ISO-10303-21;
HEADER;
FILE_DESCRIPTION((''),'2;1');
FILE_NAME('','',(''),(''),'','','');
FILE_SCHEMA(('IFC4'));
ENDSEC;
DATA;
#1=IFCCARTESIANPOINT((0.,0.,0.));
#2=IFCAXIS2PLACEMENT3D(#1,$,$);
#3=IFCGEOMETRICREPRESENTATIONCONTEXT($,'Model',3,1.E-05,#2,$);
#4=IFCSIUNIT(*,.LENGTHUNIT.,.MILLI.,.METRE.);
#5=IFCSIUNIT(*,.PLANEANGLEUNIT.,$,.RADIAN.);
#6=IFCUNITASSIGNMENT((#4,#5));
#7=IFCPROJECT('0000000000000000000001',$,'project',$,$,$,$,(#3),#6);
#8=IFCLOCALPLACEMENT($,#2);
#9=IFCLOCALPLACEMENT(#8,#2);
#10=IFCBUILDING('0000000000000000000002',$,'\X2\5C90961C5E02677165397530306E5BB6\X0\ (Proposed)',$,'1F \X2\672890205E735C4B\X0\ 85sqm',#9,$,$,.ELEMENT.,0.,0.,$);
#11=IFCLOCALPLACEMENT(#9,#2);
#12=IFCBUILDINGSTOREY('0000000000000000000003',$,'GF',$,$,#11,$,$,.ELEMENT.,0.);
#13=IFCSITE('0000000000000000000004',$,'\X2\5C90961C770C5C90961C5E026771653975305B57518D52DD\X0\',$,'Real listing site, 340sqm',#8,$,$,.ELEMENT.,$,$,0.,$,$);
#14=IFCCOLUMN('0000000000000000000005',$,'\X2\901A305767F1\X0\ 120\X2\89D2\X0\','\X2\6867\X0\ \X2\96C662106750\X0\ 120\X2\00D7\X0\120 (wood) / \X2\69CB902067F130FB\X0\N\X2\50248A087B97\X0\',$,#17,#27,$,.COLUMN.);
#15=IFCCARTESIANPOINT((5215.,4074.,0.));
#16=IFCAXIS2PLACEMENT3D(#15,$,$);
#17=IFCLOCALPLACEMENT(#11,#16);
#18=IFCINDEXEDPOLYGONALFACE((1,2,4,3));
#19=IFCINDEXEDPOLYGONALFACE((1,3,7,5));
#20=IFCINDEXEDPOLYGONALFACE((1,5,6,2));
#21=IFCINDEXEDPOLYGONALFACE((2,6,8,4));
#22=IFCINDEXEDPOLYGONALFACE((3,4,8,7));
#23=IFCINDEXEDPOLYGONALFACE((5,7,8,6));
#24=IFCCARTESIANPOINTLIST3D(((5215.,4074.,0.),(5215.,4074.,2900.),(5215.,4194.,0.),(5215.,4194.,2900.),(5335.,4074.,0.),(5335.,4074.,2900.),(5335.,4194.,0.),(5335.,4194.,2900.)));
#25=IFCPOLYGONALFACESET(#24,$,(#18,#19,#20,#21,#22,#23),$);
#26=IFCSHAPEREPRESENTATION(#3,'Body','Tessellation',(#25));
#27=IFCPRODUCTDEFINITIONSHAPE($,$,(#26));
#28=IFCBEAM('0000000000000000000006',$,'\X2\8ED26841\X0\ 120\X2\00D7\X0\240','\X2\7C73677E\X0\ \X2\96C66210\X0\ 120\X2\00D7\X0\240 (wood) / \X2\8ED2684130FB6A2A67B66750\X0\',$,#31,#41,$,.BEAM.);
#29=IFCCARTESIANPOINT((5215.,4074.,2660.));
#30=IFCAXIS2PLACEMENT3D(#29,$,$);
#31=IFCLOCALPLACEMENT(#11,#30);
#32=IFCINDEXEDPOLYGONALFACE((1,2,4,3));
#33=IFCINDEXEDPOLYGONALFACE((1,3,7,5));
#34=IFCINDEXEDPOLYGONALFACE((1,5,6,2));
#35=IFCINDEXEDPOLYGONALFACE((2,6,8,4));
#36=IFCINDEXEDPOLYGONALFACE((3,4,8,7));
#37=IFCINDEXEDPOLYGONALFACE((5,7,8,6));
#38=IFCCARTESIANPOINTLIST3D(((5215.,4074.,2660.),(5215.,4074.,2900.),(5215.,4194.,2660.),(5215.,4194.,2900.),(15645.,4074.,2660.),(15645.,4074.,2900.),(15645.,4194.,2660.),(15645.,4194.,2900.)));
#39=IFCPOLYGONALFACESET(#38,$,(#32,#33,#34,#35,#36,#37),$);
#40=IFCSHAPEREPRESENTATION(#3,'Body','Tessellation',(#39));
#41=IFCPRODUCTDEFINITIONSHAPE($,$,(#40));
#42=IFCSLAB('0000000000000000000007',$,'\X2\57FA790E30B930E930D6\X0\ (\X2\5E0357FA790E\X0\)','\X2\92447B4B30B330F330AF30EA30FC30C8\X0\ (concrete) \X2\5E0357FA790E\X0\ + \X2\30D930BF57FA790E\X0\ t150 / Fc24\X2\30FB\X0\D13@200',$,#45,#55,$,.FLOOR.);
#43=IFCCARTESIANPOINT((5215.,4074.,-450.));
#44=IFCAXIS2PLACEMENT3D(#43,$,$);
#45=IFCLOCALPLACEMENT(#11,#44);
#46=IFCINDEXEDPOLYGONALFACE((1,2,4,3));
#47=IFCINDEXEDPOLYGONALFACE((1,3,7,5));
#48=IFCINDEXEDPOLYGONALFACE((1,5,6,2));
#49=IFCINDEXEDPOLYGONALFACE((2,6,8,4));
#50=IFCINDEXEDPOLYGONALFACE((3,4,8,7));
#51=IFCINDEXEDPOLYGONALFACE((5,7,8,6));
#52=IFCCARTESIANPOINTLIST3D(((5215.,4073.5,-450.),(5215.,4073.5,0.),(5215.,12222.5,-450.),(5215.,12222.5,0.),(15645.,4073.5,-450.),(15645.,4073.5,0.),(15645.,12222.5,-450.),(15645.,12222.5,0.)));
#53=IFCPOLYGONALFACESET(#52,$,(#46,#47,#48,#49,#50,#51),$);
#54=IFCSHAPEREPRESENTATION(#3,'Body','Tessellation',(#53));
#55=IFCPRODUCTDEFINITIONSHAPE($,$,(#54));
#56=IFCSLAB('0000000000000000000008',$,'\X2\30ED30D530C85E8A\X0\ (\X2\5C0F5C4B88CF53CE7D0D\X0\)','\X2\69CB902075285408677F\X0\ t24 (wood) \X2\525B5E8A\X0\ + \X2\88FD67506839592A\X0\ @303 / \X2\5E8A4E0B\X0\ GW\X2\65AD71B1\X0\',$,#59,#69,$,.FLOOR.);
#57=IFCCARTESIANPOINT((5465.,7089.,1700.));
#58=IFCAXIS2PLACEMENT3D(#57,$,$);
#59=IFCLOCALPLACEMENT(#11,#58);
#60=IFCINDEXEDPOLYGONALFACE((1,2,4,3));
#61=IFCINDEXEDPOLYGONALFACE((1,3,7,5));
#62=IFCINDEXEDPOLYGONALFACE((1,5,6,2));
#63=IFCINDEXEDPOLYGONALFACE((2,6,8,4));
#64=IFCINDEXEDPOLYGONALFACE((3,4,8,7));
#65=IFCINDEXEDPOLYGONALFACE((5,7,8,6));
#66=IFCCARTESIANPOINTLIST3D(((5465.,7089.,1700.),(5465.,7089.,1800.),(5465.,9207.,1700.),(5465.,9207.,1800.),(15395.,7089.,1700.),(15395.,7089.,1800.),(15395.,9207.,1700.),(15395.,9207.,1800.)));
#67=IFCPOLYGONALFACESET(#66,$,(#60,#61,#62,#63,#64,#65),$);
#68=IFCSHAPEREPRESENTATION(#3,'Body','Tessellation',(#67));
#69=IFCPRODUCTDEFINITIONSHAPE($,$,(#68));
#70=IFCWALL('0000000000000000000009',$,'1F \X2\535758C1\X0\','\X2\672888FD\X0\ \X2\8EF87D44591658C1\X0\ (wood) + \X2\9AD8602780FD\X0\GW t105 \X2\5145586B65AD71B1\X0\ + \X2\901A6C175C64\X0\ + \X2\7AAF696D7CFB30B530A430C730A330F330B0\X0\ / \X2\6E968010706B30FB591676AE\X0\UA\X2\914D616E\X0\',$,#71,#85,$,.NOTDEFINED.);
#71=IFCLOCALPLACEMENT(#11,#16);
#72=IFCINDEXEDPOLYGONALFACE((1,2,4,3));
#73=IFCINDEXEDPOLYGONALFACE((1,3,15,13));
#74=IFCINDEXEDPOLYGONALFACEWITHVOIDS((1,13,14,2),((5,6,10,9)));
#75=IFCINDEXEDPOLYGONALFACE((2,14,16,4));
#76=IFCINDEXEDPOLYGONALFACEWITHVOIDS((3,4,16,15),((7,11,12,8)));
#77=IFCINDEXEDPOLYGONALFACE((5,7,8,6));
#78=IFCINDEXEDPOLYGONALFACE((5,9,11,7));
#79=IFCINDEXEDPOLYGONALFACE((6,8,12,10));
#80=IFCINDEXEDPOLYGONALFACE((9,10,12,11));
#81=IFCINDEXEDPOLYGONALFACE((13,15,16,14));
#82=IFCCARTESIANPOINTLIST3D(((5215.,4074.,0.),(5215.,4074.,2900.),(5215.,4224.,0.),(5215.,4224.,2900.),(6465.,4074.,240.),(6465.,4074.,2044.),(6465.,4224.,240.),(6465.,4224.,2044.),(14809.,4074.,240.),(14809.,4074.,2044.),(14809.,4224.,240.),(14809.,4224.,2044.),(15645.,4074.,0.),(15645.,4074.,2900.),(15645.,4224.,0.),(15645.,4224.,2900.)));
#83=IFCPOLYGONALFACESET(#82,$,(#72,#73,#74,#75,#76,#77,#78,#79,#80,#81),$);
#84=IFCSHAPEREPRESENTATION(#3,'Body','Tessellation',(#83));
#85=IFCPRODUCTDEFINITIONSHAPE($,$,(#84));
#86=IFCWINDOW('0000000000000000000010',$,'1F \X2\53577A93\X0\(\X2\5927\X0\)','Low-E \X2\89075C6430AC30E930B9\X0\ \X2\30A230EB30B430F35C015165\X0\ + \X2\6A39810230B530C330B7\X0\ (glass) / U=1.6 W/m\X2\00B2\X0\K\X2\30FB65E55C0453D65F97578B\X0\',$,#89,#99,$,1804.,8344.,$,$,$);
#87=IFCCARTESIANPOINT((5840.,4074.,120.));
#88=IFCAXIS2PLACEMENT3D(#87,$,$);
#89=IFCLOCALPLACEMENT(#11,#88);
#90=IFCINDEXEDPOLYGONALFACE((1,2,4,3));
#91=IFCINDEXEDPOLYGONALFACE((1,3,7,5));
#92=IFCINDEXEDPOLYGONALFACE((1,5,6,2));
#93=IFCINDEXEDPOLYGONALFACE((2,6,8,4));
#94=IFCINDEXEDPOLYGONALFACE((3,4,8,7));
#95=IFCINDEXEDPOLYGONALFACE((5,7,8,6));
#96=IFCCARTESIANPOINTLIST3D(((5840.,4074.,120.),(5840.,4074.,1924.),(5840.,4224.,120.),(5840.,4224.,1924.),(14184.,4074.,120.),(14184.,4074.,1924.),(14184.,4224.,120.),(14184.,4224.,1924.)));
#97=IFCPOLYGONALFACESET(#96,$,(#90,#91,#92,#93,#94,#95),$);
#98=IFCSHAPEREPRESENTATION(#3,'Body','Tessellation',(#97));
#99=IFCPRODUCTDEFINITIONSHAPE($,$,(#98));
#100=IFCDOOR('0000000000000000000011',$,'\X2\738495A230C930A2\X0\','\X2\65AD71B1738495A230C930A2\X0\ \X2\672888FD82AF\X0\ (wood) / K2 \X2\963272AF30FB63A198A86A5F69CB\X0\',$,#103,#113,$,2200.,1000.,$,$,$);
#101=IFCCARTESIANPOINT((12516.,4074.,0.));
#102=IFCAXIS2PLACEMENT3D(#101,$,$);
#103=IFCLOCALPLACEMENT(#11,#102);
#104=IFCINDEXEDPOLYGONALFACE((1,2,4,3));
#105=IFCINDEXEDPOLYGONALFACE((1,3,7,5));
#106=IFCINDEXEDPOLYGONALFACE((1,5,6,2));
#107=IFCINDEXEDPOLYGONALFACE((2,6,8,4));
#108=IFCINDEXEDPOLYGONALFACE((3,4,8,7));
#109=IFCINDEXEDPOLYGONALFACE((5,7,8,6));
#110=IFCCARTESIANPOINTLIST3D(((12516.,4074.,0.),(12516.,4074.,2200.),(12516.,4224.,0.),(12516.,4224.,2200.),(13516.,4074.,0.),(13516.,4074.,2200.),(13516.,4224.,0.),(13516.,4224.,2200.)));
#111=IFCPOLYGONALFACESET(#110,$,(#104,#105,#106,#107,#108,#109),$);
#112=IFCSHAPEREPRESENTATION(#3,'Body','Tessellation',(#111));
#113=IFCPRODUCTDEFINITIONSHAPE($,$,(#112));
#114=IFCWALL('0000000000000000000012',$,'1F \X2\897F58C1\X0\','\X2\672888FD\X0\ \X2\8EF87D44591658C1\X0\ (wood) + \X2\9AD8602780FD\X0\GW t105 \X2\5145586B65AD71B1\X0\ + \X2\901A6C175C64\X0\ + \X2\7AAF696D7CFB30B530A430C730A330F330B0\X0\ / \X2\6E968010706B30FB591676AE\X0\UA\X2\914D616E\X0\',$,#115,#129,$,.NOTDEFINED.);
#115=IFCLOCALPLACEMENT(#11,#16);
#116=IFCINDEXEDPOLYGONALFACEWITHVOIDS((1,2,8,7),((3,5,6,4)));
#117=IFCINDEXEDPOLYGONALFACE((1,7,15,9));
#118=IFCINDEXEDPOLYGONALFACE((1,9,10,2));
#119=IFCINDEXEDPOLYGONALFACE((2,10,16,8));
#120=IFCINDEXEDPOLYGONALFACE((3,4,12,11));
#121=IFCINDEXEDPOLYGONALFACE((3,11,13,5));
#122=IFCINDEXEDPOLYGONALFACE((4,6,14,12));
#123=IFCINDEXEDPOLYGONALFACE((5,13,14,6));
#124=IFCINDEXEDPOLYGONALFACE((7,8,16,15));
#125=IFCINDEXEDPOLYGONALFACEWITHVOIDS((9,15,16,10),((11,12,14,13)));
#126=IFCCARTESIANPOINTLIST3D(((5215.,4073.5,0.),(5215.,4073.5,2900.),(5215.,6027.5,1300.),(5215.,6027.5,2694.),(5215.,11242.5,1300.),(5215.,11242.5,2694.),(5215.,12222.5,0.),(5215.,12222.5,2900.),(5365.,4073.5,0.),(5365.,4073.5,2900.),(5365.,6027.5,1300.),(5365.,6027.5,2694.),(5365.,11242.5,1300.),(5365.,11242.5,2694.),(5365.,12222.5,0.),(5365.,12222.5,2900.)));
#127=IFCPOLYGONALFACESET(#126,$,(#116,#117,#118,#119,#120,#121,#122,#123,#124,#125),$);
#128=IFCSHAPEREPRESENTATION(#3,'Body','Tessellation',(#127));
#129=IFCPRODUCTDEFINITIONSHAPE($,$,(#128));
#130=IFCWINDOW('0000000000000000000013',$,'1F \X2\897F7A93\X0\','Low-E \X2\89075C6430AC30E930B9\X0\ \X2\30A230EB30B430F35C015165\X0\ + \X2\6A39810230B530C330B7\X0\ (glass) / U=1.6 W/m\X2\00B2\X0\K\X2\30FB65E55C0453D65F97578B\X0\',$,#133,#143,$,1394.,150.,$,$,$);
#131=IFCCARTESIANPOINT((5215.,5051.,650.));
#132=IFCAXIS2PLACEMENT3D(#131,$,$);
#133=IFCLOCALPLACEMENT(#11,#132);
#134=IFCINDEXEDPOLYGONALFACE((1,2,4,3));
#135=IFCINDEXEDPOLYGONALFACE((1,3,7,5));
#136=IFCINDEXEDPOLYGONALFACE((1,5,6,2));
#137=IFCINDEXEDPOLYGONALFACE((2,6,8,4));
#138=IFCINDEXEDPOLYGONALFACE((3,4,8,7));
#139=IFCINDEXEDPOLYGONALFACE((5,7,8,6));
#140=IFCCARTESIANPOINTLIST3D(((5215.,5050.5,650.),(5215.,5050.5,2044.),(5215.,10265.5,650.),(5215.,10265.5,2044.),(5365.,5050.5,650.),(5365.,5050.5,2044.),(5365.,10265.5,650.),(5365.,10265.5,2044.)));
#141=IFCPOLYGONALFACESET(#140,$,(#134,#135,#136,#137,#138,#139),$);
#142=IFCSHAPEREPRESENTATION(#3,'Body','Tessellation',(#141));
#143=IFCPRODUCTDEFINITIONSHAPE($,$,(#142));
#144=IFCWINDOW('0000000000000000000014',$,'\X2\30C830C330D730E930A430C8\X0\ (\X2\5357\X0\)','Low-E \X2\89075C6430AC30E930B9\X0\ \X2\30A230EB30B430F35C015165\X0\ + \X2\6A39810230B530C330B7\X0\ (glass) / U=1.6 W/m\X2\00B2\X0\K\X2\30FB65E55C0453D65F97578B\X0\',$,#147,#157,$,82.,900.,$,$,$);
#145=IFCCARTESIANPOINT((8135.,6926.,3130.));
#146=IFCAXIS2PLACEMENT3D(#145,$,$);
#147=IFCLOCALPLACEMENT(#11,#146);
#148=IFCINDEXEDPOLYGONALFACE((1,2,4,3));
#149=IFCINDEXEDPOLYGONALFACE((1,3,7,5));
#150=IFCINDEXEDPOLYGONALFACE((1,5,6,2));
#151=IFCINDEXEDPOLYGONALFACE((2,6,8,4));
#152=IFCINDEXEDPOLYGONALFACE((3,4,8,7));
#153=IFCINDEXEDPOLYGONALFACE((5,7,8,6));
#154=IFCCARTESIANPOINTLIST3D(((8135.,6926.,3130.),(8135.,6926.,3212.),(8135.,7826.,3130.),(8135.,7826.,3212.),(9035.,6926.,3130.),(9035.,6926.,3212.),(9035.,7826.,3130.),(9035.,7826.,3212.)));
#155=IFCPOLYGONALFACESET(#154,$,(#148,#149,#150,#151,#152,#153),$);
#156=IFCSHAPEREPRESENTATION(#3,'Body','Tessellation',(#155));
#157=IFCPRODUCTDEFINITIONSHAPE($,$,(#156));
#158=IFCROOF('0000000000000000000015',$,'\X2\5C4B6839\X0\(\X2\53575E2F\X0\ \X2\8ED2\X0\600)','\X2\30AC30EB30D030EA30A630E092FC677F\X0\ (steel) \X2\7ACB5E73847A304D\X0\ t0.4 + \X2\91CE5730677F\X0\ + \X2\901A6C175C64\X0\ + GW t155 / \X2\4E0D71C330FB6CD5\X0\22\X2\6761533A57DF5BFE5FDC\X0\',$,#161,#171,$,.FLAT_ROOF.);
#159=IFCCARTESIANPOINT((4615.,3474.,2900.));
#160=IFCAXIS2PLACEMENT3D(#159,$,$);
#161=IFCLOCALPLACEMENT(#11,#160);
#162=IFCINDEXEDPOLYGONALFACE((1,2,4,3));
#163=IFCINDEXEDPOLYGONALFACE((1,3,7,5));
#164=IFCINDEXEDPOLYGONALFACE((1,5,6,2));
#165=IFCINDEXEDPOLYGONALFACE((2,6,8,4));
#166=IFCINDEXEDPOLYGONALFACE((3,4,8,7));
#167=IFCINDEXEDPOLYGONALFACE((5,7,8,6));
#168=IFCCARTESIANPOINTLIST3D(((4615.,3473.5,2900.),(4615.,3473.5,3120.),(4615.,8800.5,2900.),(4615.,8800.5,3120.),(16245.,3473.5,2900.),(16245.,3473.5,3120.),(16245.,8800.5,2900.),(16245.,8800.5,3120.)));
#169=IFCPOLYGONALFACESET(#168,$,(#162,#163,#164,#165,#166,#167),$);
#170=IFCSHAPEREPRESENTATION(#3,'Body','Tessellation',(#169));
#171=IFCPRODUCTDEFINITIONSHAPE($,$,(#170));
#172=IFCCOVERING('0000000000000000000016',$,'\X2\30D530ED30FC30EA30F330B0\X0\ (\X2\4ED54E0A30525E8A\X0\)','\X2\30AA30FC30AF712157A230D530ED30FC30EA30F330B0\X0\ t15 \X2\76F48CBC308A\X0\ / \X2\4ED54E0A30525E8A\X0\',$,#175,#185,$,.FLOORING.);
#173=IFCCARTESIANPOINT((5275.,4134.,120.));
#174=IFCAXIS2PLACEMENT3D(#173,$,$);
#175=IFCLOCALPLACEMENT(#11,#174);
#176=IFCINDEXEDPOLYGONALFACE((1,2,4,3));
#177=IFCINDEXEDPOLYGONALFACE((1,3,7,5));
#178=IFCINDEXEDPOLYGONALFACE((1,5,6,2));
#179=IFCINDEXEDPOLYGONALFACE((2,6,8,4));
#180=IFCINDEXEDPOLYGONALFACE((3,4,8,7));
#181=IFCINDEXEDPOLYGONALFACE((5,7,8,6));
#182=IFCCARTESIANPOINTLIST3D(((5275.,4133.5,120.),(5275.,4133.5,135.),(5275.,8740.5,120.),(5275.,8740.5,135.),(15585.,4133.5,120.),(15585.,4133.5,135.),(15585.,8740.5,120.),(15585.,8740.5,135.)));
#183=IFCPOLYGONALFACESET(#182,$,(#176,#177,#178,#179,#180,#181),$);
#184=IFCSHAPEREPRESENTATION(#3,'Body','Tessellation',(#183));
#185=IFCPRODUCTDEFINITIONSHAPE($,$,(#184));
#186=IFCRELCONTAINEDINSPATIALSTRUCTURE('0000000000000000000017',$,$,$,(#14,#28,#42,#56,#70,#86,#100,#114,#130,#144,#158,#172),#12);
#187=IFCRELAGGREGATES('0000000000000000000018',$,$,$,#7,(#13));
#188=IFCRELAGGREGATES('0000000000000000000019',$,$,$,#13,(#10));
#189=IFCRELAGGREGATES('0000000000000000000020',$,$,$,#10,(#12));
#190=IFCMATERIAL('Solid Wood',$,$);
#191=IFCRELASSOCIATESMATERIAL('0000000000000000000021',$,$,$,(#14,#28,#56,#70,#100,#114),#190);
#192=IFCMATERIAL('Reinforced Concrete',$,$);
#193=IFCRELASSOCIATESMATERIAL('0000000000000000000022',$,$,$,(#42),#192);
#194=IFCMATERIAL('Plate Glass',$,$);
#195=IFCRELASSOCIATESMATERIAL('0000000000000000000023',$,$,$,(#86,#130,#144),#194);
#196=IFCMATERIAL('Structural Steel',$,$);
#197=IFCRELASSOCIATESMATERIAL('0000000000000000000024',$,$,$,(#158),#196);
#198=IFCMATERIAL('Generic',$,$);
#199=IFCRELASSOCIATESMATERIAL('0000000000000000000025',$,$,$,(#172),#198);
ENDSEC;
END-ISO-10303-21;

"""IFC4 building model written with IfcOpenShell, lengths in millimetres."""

from ifc_helpers import new_model, si_unit, frame, frame_2d, origin, place, context, project, spatial, rectangle, extrude, material, element, fill, save


model = new_model("IFC4")

# Units and contexts
model_context = context("Model", 3, precision=1e-05, world=origin())
ifc_project = project(units=[si_unit("LENGTHUNIT", "METRE", prefix="MILLI"), si_unit("PLANEANGLEUNIT", "RADIAN")], contexts=[model_context])

# Site, building, storey
site_placement = place(None, origin())
site = spatial("IfcSite", under=ifc_project, at=site_placement, Name="岐阜県岐阜市東改田字再勝", ObjectType="Real listing site, 340sqm", CompositionType="ELEMENT", RefElevation=0.0)
building_placement = place(site_placement, origin())
building = spatial("IfcBuilding", under=site, at=building_placement, Name="岐阜市東改田の家 (Proposed)", ObjectType="1F 木造平屋 85sqm", CompositionType="ELEMENT", ElevationOfRefHeight=0.0, ElevationOfTerrain=0.0)
storey_placement = place(building_placement, origin())
storey = spatial("IfcBuildingStorey", under=building, at=storey_placement, Name="GF", CompositionType="ELEMENT", Elevation=0.0)

# Column
ifc_material_1 = material(Name="Solid Wood")
column_1_placement = place(storey_placement, frame((5215.0, 4074.0, 0.0)))
element("IfcColumn", 1, at=column_1_placement, inside=storey, material=ifc_material_1, Name="通し柱 120角", Description="桧 集成材 120×120 (wood) / 構造柱・N値計算", PredefinedType="COLUMN", context=model_context, shape_type="SweptSolid", body=[
    extrude(rectangle(XDim=120.0, YDim=120.0, at=frame_2d((60.0, 60.0))), frame((5215.0, 4074.0, 0.0)), (0.0, 0.0, 1.0), 2900.0),
])

# Beam
beam_1_placement = place(storey_placement, frame((5215.0, 4074.0, 2660.0)))
element("IfcBeam", 2, at=beam_1_placement, inside=storey, material=ifc_material_1, Name="軒桁 120×240", Description="米松 集成 120×240 (wood) / 軒桁・横架材", PredefinedType="BEAM", context=model_context, shape_type="SweptSolid", body=[
    extrude(rectangle(XDim=10430.0, YDim=120.0, at=frame_2d((5215.0, 60.0))), frame((5215.0, 4074.0, 2660.0)), (0.0, 0.0, 1.0), 240.0),
])

# Slabs
ifc_material_2 = material(Name="Reinforced Concrete")
slab_1_placement = place(storey_placement, frame((5215.0, 4074.0, -450.0)))
element("IfcSlab", 3, at=slab_1_placement, inside=storey, material=ifc_material_2, Name="基礎スラブ (布基礎)", Description="鉄筋コンクリート (concrete) 布基礎 + ベタ基礎 t150 / Fc24・D13@200", PredefinedType="FLOOR", context=model_context, shape_type="SweptSolid", body=[
    extrude(rectangle(XDim=10430.0, YDim=8149.0, at=frame_2d((5215.0, 4074.0))), frame((5215.0, 4074.0, -450.0)), (0.0, 0.0, 1.0), 450.0),
])
slab_2_placement = place(storey_placement, frame((5465.0, 7089.0, 1700.0)))
element("IfcSlab", 4, at=slab_2_placement, inside=storey, material=ifc_material_1, Name="ロフト床 (小屋裏収納)", Description="構造用合板 t24 (wood) 剛床 + 製材根太 @303 / 床下 GW断熱", PredefinedType="FLOOR", context=model_context, shape_type="SweptSolid", body=[
    extrude(rectangle(XDim=9930.0, YDim=2118.0, at=frame_2d((4965.0, 1059.0))), frame((5465.0, 7089.0, 1700.0)), (0.0, 0.0, 1.0), 100.0),
])

# Wall, openings, window, door
wall_1_placement = place(storey_placement, frame((5215.0, 4074.0, 0.0)))
wall_1 = element("IfcWall", 5, at=wall_1_placement, inside=storey, material=ifc_material_1, Name="1F 南壁", Description="木製 軸組外壁 (wood) + 高性能GW t105 充填断熱 + 通気層 + 窯業系サイディング / 準耐火・外皮UA配慮", PredefinedType="NOTDEFINED", context=model_context, shape_type="SweptSolid", body=[
    extrude(rectangle(XDim=10430.0, YDim=150.0, at=frame_2d((5215.0, 75.0))), frame((5215.0, 4074.0, 0.0)), (0.0, 0.0, 1.0), 2900.0),
])
opening_1_placement = place(storey_placement, frame((5840.0, 4074.0, 120.0)))
opening_1 = element("IfcOpeningElement", 6, at=opening_1_placement, cuts=wall_1, PredefinedType="NOTDEFINED", context=model_context, shape_type="SweptSolid", body=[
    extrude(rectangle(XDim=8344.0, YDim=150.0, at=frame_2d((4172.0, 75.0))), frame((5840.0, 4074.0, 120.0)), (0.0, 0.0, 1.0), 1804.0),
])
opening_2_placement = place(storey_placement, frame((12516.0, 4074.0, 0.0)))
opening_2 = element("IfcOpeningElement", 7, at=opening_2_placement, cuts=wall_1, PredefinedType="NOTDEFINED", context=model_context, shape_type="SweptSolid", body=[
    extrude(rectangle(XDim=1000.0, YDim=150.0, at=frame_2d((500.0, 75.0))), frame((12516.0, 4074.0, 0.0)), (0.0, 0.0, 1.0), 2200.0),
])
ifc_material_3 = material(Name="Plate Glass")
window_1_placement = place(storey_placement, frame((5840.0, 4074.0, 120.0)))
window_1 = element("IfcWindow", 8, at=window_1_placement, inside=storey, material=ifc_material_3, Name="1F 南窓(大)", Description="Low-E 複層ガラス アルゴン封入 + 樹脂サッシ (glass) / U=1.6 W/m²K・日射取得型", OverallHeight=1804.0, OverallWidth=8344.0, context=model_context, shape_type="SweptSolid", body=[
    extrude(rectangle(XDim=8344.0, YDim=150.0, at=frame_2d((4172.0, 75.0))), frame((5840.0, 4074.0, 120.0)), (0.0, 0.0, 1.0), 1804.0),
])
fill(opening_1, window_1)
door_placement = place(storey_placement, frame((12516.0, 4074.0, 0.0)))
door = element("IfcDoor", 9, at=door_placement, inside=storey, material=ifc_material_1, Name="玄関ドア", Description="断熱玄関ドア 木製芯 (wood) / K2 防犯・採風機構", OverallHeight=2200.0, OverallWidth=1000.0, context=model_context, shape_type="SweptSolid", body=[
    extrude(rectangle(XDim=1000.0, YDim=150.0, at=frame_2d((500.0, 75.0))), frame((12516.0, 4074.0, 0.0)), (0.0, 0.0, 1.0), 2200.0),
])
fill(opening_2, door)

# Wall, opening, window
wall_2_placement = place(storey_placement, frame((5215.0, 4074.0, 0.0)))
wall_2 = element("IfcWall", 10, at=wall_2_placement, inside=storey, material=ifc_material_1, Name="1F 西壁", Description="木製 軸組外壁 (wood) + 高性能GW t105 充填断熱 + 通気層 + 窯業系サイディング / 準耐火・外皮UA配慮", PredefinedType="NOTDEFINED", context=model_context, shape_type="SweptSolid", body=[
    extrude(rectangle(XDim=150.0, YDim=8149.0, at=frame_2d((75.0, 4074.0))), frame((5215.0, 4074.0, 0.0)), (0.0, 0.0, 1.0), 2900.0),
])
opening_3_placement = place(storey_placement, frame((5215.0, 5051.0, 650.0)))
opening_3 = element("IfcOpeningElement", 11, at=opening_3_placement, cuts=wall_2, PredefinedType="NOTDEFINED", context=model_context, shape_type="SweptSolid", body=[
    extrude(rectangle(XDim=150.0, YDim=5215.0, at=frame_2d((75.0, 2607.0))), frame((5215.0, 5051.0, 650.0)), (0.0, 0.0, 1.0), 1394.0),
])
window_2_placement = place(storey_placement, frame((5215.0, 5051.0, 650.0)))
window_2 = element("IfcWindow", 12, at=window_2_placement, inside=storey, material=ifc_material_3, Name="1F 西窓", Description="Low-E 複層ガラス アルゴン封入 + 樹脂サッシ (glass) / U=1.6 W/m²K・日射取得型", OverallHeight=1394.0, OverallWidth=150.0, context=model_context, shape_type="SweptSolid", body=[
    extrude(rectangle(XDim=150.0, YDim=5215.0, at=frame_2d((75.0, 2607.0))), frame((5215.0, 5051.0, 650.0)), (0.0, 0.0, 1.0), 1394.0),
])
fill(opening_3, window_2)

# Window
window_3_placement = place(storey_placement, frame((8135.0, 6926.0, 3130.0)))
element("IfcWindow", 13, at=window_3_placement, inside=storey, material=ifc_material_3, Name="トップライト (南)", Description="Low-E 複層ガラス アルゴン封入 + 樹脂サッシ (glass) / U=1.6 W/m²K・日射取得型", OverallHeight=82.0, OverallWidth=900.0, context=model_context, shape_type="SweptSolid", body=[
    extrude(rectangle(XDim=900.0, YDim=900.0, at=frame_2d((450.0, 450.0))), frame((8135.0, 6926.0, 3130.0)), (0.0, 0.0, 1.0), 82.0),
])

# Roof
ifc_material_4 = material(Name="Structural Steel")
roof_placement = place(storey_placement, frame((4615.0, 3474.0, 2900.0)))
element("IfcRoof", 14, at=roof_placement, inside=storey, material=ifc_material_4, Name="屋根(南帯 軒600)", Description="ガルバリウム鋼板 (steel) 立平葺き t0.4 + 野地板 + 通気層 + GW t155 / 不燃・法22条区域対応", PredefinedType="FLAT_ROOF", context=model_context, shape_type="SweptSolid", body=[
    extrude(rectangle(XDim=11630.0, YDim=5327.0, at=frame_2d((5815.0, 2663.0))), frame((4615.0, 3474.0, 2900.0)), (0.0, 0.0, 1.0), 220.0),
])

# Covering
ifc_material_5 = material(Name="Generic")
covering_1_placement = place(storey_placement, frame((5275.0, 4134.0, 120.0)))
element("IfcCovering", 15, at=covering_1_placement, inside=storey, material=ifc_material_5, Name="フローリング (仕上げ床)", Description="オーク無垢フローリング t15 直貼り / 仕上げ床", PredefinedType="FLOORING", context=model_context, shape_type="SweptSolid", body=[
    extrude(rectangle(XDim=10310.0, YDim=4607.0, at=frame_2d((5155.0, 2303.0))), frame((5275.0, 4134.0, 120.0)), (0.0, 0.0, 1.0), 15.0),
])

save(model, "model.ifc")
